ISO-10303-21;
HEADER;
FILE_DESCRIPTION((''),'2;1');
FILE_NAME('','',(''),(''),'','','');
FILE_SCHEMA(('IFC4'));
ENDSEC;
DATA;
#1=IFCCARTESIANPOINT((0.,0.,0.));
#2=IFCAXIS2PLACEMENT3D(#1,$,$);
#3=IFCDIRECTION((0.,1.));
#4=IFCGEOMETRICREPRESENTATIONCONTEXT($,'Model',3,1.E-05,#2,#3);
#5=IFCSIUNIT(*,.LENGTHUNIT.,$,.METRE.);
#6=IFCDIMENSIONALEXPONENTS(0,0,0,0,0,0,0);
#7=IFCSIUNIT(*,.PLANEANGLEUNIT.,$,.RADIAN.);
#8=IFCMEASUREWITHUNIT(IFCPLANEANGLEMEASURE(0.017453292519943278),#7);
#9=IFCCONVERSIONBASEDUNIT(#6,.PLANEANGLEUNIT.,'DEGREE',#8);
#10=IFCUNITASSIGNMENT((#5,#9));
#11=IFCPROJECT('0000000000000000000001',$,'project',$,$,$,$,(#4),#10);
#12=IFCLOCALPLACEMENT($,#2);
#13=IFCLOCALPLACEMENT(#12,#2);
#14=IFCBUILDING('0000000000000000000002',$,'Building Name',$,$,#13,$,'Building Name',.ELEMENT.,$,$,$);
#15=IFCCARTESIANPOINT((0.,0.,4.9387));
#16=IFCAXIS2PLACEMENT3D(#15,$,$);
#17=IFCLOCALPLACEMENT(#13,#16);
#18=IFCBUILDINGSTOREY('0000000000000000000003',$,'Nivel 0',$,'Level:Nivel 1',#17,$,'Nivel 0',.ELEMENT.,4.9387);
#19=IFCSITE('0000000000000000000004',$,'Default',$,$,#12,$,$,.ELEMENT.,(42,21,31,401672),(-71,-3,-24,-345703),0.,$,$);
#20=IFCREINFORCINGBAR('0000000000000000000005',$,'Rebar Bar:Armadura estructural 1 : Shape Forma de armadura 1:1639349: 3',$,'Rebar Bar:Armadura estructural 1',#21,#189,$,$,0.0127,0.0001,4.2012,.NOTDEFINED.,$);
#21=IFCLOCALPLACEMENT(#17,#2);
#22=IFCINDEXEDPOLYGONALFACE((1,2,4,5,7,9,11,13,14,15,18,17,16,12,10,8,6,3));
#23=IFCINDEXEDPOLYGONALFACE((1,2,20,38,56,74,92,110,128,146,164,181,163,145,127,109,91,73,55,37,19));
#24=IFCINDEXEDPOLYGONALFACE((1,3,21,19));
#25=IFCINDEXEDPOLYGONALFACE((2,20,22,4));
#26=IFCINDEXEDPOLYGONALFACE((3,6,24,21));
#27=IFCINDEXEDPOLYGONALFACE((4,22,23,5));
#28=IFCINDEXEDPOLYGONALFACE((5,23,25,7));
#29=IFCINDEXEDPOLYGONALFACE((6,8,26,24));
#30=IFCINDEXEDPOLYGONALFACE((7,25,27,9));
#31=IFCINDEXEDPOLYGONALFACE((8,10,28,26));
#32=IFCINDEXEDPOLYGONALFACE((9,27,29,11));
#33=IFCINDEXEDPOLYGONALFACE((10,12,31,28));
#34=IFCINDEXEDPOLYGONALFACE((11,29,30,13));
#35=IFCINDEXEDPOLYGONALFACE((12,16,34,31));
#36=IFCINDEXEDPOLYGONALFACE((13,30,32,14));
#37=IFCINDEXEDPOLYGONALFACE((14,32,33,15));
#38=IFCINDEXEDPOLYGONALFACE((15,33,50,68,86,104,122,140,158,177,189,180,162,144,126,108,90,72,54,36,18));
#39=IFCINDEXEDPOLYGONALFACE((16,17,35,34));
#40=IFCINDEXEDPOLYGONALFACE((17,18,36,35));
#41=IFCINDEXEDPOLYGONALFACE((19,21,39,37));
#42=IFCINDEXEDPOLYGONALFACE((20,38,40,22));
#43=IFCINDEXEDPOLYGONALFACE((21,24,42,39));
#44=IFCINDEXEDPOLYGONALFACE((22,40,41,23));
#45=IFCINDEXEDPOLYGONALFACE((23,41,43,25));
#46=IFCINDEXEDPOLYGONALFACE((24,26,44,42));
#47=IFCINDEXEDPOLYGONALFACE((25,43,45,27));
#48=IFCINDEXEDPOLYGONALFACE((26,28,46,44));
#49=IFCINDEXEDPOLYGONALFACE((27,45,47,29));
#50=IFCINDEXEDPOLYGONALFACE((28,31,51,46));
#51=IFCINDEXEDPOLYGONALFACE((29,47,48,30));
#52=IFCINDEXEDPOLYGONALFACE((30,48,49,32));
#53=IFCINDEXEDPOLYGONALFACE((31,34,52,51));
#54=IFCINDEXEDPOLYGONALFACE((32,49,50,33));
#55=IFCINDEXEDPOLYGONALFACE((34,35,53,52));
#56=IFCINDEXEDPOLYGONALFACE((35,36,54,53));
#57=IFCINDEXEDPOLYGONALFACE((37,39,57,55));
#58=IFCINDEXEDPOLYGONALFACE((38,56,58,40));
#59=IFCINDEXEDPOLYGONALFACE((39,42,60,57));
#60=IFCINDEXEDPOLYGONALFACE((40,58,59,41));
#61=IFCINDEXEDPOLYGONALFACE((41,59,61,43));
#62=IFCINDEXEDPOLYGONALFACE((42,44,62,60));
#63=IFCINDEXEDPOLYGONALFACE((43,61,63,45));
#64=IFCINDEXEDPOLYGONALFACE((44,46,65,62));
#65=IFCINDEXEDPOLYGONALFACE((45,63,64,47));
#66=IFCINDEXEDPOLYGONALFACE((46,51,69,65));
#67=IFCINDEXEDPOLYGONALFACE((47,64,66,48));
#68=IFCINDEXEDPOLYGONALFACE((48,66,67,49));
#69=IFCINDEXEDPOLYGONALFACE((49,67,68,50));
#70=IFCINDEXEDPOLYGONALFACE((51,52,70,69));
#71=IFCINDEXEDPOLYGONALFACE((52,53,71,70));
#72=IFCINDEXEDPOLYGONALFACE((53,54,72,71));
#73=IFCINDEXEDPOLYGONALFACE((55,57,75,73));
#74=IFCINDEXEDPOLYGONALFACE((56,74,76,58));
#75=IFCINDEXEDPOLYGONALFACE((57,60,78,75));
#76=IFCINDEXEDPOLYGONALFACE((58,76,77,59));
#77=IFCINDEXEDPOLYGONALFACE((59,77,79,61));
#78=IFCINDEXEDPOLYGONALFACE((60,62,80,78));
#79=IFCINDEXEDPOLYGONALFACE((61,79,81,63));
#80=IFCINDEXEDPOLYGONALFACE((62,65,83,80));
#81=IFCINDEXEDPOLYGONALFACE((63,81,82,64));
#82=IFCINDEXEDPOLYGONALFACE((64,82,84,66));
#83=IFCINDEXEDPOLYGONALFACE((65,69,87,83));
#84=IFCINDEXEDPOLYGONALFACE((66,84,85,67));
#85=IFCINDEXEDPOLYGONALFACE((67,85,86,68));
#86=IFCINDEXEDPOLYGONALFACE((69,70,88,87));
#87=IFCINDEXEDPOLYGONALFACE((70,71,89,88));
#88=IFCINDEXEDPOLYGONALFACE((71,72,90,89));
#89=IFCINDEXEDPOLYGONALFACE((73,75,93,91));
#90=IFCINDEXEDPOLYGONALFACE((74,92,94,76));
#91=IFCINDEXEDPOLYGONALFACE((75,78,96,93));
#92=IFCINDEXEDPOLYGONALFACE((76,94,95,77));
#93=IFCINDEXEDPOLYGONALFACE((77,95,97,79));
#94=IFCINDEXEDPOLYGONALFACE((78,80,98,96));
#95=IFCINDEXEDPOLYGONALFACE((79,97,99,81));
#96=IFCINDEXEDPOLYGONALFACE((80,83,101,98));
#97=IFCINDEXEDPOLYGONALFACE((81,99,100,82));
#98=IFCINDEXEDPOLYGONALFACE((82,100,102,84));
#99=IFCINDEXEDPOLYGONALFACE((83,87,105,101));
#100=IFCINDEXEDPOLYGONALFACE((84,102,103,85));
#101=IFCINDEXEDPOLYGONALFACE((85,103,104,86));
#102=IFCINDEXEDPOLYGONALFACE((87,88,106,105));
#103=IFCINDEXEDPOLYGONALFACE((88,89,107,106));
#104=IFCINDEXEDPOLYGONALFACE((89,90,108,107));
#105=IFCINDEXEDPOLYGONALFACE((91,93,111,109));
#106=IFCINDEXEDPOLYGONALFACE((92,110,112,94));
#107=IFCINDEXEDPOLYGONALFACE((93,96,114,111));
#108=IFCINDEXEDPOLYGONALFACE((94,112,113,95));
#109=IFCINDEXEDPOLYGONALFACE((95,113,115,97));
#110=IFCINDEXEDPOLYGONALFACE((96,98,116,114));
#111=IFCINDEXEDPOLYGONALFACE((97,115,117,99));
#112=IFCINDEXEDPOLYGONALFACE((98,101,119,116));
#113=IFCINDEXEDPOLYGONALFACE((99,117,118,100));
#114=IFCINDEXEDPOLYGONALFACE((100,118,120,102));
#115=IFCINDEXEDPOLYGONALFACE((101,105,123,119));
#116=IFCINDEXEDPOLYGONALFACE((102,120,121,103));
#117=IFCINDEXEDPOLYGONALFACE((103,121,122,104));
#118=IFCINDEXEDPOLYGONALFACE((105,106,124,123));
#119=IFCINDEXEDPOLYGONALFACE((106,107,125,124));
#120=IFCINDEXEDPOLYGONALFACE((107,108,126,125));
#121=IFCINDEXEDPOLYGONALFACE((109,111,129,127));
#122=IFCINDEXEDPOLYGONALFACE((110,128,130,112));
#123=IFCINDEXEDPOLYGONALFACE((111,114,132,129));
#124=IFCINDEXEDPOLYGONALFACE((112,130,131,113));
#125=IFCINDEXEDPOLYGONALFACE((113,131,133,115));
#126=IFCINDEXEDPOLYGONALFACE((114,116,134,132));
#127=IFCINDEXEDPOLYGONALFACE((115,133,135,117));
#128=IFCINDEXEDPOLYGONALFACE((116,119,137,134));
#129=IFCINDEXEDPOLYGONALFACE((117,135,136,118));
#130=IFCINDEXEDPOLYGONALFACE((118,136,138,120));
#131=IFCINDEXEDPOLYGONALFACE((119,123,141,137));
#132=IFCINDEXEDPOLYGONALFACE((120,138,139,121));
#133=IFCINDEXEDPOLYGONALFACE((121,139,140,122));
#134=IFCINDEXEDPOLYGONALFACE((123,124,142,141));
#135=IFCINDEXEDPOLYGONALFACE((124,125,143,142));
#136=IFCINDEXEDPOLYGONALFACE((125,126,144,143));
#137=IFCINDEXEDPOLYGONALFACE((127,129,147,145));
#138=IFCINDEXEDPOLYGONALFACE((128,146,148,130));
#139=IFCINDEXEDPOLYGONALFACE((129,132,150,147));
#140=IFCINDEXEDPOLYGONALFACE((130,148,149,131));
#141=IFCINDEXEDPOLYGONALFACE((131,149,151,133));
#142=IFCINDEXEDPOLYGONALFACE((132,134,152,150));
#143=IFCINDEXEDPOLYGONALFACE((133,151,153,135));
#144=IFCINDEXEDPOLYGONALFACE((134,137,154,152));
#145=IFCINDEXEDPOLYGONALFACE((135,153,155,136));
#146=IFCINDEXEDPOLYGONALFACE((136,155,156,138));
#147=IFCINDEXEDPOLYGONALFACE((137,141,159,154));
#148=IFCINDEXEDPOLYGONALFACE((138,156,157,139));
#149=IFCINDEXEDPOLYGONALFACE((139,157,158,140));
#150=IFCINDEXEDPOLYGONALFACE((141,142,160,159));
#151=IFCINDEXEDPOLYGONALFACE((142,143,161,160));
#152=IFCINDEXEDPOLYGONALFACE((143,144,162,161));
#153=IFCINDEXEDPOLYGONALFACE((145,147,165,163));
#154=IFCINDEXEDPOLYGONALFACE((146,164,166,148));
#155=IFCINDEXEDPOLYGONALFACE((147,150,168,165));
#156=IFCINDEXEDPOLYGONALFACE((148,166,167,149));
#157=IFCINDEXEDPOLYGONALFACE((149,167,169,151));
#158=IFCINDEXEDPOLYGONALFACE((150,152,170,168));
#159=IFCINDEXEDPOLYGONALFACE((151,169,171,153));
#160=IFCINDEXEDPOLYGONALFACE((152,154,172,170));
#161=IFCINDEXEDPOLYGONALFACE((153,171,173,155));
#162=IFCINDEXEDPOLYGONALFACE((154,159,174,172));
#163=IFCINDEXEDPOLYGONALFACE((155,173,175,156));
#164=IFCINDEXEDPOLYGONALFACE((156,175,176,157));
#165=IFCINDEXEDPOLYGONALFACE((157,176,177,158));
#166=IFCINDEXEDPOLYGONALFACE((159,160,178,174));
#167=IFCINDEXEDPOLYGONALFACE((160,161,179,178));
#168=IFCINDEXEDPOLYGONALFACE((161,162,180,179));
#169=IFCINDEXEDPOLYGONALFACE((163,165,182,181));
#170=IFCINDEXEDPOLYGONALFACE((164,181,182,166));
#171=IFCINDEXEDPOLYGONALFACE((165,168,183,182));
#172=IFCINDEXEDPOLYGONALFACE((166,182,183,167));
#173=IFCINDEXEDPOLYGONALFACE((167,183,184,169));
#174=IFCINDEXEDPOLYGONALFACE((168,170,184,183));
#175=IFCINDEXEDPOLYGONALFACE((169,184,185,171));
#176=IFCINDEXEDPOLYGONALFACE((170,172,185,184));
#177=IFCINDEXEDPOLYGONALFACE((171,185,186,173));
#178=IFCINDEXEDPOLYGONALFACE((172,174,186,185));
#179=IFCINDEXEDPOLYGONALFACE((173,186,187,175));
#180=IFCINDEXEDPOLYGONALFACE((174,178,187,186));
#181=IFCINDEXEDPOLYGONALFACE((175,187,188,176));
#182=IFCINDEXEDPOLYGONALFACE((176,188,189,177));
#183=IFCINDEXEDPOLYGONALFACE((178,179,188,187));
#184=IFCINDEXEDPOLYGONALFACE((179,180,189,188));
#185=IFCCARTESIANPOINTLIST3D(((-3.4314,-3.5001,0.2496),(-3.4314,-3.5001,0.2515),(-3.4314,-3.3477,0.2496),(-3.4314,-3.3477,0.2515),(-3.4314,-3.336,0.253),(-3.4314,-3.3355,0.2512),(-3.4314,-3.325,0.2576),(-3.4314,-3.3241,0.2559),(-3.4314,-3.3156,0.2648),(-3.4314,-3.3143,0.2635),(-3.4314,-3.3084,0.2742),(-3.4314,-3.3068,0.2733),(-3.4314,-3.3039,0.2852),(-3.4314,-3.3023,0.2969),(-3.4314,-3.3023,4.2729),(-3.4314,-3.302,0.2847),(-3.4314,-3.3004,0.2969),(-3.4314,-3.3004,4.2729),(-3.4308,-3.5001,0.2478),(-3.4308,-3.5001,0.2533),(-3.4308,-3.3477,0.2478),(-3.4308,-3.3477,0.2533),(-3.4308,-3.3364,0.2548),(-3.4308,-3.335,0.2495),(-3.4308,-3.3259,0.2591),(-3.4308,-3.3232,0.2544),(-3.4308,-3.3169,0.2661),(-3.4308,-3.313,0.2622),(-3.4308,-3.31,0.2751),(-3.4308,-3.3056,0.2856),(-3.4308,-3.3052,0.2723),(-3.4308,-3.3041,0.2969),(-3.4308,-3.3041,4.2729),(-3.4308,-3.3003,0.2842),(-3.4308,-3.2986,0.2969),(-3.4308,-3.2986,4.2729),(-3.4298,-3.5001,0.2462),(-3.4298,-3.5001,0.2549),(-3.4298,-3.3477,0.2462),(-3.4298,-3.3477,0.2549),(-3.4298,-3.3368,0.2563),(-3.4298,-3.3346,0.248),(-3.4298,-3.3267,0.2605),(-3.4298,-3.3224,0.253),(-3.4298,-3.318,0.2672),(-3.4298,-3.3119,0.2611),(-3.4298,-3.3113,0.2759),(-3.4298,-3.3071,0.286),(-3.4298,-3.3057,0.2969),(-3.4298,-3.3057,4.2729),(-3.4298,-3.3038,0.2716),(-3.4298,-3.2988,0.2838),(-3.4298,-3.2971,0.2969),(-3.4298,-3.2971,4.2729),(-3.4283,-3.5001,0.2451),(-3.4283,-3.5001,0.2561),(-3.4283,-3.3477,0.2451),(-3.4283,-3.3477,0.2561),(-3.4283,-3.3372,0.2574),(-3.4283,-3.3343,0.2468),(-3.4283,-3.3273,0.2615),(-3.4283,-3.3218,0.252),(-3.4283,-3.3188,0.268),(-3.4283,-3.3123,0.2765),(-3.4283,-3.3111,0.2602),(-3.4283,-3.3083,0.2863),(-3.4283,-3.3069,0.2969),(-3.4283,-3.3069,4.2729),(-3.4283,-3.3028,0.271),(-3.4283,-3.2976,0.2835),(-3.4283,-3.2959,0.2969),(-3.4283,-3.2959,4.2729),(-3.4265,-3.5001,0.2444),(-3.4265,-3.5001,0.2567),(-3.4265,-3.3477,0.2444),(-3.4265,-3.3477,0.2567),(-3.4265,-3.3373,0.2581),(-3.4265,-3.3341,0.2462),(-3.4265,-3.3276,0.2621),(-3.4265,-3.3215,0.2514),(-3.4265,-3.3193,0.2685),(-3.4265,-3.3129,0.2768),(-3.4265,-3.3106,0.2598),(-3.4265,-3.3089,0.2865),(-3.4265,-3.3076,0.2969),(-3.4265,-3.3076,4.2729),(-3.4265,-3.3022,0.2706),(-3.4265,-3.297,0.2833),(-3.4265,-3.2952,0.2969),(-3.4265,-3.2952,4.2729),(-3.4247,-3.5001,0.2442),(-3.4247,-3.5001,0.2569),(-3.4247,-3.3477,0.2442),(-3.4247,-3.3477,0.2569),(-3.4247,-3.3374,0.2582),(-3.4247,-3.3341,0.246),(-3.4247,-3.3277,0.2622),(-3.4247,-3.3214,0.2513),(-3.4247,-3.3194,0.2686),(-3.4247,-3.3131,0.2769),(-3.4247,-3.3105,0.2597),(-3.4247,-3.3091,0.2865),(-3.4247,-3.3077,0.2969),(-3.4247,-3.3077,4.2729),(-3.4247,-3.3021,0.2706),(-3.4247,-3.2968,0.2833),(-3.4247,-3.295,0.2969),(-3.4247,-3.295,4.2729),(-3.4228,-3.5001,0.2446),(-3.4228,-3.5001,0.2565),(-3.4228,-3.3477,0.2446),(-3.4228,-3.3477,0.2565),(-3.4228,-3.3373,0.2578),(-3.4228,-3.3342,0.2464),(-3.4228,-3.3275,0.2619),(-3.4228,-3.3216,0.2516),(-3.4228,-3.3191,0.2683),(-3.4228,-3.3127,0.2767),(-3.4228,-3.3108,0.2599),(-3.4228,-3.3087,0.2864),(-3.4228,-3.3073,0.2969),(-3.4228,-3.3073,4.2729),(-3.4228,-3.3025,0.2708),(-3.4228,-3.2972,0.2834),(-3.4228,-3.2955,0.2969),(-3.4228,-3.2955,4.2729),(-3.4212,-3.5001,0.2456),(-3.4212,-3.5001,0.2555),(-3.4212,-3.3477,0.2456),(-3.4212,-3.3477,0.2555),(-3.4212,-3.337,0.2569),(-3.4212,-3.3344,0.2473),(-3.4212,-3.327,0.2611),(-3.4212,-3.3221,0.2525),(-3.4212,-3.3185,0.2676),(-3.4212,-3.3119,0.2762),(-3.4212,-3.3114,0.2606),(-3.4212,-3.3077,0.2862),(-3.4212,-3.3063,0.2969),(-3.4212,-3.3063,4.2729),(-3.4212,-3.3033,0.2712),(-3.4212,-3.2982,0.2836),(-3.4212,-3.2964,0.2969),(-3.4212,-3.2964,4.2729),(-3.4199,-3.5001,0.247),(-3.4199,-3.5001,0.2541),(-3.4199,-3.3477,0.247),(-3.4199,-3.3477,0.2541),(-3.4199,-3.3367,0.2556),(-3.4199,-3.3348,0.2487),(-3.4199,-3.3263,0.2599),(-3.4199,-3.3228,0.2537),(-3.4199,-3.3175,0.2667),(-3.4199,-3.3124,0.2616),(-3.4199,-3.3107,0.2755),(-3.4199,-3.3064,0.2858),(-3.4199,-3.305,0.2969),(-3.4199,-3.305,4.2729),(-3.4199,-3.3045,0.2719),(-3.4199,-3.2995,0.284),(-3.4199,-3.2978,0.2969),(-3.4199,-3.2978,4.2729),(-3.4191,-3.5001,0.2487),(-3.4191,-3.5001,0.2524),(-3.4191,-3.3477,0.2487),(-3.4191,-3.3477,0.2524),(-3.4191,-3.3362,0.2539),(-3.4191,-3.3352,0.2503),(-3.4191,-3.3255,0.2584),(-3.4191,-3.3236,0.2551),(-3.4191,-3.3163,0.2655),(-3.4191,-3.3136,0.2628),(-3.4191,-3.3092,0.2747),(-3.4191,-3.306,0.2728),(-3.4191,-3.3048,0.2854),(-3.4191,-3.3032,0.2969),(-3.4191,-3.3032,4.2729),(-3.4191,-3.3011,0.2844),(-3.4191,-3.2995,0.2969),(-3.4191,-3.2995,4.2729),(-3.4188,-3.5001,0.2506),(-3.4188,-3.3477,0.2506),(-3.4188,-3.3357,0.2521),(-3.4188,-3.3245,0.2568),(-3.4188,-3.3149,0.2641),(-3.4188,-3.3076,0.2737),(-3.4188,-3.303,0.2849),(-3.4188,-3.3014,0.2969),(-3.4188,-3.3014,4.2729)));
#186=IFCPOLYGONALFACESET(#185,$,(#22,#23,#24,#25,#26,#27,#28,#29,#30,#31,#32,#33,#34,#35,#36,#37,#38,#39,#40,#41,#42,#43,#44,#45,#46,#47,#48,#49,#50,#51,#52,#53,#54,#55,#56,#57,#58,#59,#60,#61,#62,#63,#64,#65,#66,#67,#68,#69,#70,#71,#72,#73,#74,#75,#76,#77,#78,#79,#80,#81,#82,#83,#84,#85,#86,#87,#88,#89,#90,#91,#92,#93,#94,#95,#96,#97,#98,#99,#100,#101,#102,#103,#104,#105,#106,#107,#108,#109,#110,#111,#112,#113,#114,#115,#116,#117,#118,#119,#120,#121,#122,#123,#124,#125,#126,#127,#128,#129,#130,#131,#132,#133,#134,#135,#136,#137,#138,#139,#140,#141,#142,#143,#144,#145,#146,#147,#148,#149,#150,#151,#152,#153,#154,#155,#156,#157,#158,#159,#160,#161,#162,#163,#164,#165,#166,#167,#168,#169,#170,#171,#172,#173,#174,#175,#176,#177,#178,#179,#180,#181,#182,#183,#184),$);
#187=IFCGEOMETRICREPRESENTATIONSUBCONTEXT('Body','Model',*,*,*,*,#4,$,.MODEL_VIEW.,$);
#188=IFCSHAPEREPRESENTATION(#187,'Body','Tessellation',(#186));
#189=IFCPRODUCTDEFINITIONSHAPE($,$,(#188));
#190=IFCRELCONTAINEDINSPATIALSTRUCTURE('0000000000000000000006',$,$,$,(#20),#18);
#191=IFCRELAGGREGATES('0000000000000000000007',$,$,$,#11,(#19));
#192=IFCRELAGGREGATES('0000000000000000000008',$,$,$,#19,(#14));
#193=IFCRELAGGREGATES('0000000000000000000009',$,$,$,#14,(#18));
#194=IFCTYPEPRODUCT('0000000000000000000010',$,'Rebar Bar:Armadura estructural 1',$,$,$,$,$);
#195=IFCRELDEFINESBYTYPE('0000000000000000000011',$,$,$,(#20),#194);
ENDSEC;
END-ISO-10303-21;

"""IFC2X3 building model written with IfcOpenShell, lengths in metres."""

from ifc_helpers import new_model, entity, si_unit, converted_unit, direction, frame, origin, place, context, subcontext, project, spatial, type_object, element, save


model = new_model("IFC2X3")

# Units and contexts
model_context = context("Model", 3, precision=1e-05, world=origin(), true_north=direction((0.0, 1.0)))
body_context = subcontext(model_context, "Body", "Model", "MODEL_VIEW")
ifc_project = project(units=[si_unit("LENGTHUNIT", "METRE"), converted_unit("PLANEANGLEUNIT", "DEGREE", entity("IfcPlaneAngleMeasure", 0.017453292519943278), si_unit("PLANEANGLEUNIT", "RADIAN"), dimensions=[0, 0, 0, 0, 0, 0, 0])], contexts=[model_context])

# Site, building, storey
site_placement = place(None, origin())
site = spatial("IfcSite", under=ifc_project, at=site_placement, Name="Default", CompositionType="ELEMENT", RefLatitude=(42, 21, 31, 401672), RefLongitude=(-71, -3, -24, -345703), RefElevation=0.0)
building_placement = place(site_placement, origin())
building = spatial("IfcBuilding", under=site, at=building_placement, Name="Building Name", LongName="Building Name", CompositionType="ELEMENT")
storey_placement = place(building_placement, frame((0.0, 0.0, 4.9387)))
storey = spatial("IfcBuildingStorey", under=building, at=storey_placement, Name="Nivel 0", ObjectType="Level:Nivel 1", LongName="Nivel 0", CompositionType="ELEMENT", Elevation=4.9387)

# Reinforcing bar
type_product = type_object("IfcTypeProduct", Name="Rebar Bar:Armadura estructural 1")
reinforcing_bar_1_placement = place(storey_placement, origin())
element("IfcReinforcingBar", 1, at=reinforcing_bar_1_placement, inside=storey, type_object=type_product, Name="Rebar Bar:Armadura estructural 1 : Shape Forma de armadura 1:1639349: 3", ObjectType="Rebar Bar:Armadura estructural 1", BarLength=4.2012, BarRole="NOTDEFINED", CrossSectionArea=0.0001, NominalDiameter=0.0127, context=body_context, shape_type="AdvancedSweptSolid", body=[
    entity("IfcSweptDiskSolid", entity("IfcCompositeCurve", [entity("IfcCompositeCurveSegment", "CONTINUOUS", True, entity("IfcPolyline", [entity("IfcCartesianPoint", [-3.4251, -3.5001, 0.2506]), entity("IfcCartesianPoint", [-3.4251, -3.3477, 0.2506])])), entity("IfcCompositeCurveSegment", "CONTINUOUS", True, entity("IfcTrimmedCurve", entity("IfcCircle", entity("IfcAxis2Placement3D", entity("IfcCartesianPoint", [-3.4251, -3.3477, 0.2969]), entity("IfcDirection", [1.0, 0.0, 0.0]), entity("IfcDirection", [0.0, 1.0, 0.0])), 0.0464), [entity("IfcParameterValue", 270.0)], [entity("IfcParameterValue", 360.0)], True, "PARAMETER")), entity("IfcCompositeCurveSegment", "CONTINUOUS", True, entity("IfcPolyline", [entity("IfcCartesianPoint", [-3.4251, -3.3014, 0.2969]), entity("IfcCartesianPoint", [-3.4251, -3.3014, 4.2729])]))], False), 0.0063, None, 0.0, 92.0),
])

save(model, "model.ifc")
